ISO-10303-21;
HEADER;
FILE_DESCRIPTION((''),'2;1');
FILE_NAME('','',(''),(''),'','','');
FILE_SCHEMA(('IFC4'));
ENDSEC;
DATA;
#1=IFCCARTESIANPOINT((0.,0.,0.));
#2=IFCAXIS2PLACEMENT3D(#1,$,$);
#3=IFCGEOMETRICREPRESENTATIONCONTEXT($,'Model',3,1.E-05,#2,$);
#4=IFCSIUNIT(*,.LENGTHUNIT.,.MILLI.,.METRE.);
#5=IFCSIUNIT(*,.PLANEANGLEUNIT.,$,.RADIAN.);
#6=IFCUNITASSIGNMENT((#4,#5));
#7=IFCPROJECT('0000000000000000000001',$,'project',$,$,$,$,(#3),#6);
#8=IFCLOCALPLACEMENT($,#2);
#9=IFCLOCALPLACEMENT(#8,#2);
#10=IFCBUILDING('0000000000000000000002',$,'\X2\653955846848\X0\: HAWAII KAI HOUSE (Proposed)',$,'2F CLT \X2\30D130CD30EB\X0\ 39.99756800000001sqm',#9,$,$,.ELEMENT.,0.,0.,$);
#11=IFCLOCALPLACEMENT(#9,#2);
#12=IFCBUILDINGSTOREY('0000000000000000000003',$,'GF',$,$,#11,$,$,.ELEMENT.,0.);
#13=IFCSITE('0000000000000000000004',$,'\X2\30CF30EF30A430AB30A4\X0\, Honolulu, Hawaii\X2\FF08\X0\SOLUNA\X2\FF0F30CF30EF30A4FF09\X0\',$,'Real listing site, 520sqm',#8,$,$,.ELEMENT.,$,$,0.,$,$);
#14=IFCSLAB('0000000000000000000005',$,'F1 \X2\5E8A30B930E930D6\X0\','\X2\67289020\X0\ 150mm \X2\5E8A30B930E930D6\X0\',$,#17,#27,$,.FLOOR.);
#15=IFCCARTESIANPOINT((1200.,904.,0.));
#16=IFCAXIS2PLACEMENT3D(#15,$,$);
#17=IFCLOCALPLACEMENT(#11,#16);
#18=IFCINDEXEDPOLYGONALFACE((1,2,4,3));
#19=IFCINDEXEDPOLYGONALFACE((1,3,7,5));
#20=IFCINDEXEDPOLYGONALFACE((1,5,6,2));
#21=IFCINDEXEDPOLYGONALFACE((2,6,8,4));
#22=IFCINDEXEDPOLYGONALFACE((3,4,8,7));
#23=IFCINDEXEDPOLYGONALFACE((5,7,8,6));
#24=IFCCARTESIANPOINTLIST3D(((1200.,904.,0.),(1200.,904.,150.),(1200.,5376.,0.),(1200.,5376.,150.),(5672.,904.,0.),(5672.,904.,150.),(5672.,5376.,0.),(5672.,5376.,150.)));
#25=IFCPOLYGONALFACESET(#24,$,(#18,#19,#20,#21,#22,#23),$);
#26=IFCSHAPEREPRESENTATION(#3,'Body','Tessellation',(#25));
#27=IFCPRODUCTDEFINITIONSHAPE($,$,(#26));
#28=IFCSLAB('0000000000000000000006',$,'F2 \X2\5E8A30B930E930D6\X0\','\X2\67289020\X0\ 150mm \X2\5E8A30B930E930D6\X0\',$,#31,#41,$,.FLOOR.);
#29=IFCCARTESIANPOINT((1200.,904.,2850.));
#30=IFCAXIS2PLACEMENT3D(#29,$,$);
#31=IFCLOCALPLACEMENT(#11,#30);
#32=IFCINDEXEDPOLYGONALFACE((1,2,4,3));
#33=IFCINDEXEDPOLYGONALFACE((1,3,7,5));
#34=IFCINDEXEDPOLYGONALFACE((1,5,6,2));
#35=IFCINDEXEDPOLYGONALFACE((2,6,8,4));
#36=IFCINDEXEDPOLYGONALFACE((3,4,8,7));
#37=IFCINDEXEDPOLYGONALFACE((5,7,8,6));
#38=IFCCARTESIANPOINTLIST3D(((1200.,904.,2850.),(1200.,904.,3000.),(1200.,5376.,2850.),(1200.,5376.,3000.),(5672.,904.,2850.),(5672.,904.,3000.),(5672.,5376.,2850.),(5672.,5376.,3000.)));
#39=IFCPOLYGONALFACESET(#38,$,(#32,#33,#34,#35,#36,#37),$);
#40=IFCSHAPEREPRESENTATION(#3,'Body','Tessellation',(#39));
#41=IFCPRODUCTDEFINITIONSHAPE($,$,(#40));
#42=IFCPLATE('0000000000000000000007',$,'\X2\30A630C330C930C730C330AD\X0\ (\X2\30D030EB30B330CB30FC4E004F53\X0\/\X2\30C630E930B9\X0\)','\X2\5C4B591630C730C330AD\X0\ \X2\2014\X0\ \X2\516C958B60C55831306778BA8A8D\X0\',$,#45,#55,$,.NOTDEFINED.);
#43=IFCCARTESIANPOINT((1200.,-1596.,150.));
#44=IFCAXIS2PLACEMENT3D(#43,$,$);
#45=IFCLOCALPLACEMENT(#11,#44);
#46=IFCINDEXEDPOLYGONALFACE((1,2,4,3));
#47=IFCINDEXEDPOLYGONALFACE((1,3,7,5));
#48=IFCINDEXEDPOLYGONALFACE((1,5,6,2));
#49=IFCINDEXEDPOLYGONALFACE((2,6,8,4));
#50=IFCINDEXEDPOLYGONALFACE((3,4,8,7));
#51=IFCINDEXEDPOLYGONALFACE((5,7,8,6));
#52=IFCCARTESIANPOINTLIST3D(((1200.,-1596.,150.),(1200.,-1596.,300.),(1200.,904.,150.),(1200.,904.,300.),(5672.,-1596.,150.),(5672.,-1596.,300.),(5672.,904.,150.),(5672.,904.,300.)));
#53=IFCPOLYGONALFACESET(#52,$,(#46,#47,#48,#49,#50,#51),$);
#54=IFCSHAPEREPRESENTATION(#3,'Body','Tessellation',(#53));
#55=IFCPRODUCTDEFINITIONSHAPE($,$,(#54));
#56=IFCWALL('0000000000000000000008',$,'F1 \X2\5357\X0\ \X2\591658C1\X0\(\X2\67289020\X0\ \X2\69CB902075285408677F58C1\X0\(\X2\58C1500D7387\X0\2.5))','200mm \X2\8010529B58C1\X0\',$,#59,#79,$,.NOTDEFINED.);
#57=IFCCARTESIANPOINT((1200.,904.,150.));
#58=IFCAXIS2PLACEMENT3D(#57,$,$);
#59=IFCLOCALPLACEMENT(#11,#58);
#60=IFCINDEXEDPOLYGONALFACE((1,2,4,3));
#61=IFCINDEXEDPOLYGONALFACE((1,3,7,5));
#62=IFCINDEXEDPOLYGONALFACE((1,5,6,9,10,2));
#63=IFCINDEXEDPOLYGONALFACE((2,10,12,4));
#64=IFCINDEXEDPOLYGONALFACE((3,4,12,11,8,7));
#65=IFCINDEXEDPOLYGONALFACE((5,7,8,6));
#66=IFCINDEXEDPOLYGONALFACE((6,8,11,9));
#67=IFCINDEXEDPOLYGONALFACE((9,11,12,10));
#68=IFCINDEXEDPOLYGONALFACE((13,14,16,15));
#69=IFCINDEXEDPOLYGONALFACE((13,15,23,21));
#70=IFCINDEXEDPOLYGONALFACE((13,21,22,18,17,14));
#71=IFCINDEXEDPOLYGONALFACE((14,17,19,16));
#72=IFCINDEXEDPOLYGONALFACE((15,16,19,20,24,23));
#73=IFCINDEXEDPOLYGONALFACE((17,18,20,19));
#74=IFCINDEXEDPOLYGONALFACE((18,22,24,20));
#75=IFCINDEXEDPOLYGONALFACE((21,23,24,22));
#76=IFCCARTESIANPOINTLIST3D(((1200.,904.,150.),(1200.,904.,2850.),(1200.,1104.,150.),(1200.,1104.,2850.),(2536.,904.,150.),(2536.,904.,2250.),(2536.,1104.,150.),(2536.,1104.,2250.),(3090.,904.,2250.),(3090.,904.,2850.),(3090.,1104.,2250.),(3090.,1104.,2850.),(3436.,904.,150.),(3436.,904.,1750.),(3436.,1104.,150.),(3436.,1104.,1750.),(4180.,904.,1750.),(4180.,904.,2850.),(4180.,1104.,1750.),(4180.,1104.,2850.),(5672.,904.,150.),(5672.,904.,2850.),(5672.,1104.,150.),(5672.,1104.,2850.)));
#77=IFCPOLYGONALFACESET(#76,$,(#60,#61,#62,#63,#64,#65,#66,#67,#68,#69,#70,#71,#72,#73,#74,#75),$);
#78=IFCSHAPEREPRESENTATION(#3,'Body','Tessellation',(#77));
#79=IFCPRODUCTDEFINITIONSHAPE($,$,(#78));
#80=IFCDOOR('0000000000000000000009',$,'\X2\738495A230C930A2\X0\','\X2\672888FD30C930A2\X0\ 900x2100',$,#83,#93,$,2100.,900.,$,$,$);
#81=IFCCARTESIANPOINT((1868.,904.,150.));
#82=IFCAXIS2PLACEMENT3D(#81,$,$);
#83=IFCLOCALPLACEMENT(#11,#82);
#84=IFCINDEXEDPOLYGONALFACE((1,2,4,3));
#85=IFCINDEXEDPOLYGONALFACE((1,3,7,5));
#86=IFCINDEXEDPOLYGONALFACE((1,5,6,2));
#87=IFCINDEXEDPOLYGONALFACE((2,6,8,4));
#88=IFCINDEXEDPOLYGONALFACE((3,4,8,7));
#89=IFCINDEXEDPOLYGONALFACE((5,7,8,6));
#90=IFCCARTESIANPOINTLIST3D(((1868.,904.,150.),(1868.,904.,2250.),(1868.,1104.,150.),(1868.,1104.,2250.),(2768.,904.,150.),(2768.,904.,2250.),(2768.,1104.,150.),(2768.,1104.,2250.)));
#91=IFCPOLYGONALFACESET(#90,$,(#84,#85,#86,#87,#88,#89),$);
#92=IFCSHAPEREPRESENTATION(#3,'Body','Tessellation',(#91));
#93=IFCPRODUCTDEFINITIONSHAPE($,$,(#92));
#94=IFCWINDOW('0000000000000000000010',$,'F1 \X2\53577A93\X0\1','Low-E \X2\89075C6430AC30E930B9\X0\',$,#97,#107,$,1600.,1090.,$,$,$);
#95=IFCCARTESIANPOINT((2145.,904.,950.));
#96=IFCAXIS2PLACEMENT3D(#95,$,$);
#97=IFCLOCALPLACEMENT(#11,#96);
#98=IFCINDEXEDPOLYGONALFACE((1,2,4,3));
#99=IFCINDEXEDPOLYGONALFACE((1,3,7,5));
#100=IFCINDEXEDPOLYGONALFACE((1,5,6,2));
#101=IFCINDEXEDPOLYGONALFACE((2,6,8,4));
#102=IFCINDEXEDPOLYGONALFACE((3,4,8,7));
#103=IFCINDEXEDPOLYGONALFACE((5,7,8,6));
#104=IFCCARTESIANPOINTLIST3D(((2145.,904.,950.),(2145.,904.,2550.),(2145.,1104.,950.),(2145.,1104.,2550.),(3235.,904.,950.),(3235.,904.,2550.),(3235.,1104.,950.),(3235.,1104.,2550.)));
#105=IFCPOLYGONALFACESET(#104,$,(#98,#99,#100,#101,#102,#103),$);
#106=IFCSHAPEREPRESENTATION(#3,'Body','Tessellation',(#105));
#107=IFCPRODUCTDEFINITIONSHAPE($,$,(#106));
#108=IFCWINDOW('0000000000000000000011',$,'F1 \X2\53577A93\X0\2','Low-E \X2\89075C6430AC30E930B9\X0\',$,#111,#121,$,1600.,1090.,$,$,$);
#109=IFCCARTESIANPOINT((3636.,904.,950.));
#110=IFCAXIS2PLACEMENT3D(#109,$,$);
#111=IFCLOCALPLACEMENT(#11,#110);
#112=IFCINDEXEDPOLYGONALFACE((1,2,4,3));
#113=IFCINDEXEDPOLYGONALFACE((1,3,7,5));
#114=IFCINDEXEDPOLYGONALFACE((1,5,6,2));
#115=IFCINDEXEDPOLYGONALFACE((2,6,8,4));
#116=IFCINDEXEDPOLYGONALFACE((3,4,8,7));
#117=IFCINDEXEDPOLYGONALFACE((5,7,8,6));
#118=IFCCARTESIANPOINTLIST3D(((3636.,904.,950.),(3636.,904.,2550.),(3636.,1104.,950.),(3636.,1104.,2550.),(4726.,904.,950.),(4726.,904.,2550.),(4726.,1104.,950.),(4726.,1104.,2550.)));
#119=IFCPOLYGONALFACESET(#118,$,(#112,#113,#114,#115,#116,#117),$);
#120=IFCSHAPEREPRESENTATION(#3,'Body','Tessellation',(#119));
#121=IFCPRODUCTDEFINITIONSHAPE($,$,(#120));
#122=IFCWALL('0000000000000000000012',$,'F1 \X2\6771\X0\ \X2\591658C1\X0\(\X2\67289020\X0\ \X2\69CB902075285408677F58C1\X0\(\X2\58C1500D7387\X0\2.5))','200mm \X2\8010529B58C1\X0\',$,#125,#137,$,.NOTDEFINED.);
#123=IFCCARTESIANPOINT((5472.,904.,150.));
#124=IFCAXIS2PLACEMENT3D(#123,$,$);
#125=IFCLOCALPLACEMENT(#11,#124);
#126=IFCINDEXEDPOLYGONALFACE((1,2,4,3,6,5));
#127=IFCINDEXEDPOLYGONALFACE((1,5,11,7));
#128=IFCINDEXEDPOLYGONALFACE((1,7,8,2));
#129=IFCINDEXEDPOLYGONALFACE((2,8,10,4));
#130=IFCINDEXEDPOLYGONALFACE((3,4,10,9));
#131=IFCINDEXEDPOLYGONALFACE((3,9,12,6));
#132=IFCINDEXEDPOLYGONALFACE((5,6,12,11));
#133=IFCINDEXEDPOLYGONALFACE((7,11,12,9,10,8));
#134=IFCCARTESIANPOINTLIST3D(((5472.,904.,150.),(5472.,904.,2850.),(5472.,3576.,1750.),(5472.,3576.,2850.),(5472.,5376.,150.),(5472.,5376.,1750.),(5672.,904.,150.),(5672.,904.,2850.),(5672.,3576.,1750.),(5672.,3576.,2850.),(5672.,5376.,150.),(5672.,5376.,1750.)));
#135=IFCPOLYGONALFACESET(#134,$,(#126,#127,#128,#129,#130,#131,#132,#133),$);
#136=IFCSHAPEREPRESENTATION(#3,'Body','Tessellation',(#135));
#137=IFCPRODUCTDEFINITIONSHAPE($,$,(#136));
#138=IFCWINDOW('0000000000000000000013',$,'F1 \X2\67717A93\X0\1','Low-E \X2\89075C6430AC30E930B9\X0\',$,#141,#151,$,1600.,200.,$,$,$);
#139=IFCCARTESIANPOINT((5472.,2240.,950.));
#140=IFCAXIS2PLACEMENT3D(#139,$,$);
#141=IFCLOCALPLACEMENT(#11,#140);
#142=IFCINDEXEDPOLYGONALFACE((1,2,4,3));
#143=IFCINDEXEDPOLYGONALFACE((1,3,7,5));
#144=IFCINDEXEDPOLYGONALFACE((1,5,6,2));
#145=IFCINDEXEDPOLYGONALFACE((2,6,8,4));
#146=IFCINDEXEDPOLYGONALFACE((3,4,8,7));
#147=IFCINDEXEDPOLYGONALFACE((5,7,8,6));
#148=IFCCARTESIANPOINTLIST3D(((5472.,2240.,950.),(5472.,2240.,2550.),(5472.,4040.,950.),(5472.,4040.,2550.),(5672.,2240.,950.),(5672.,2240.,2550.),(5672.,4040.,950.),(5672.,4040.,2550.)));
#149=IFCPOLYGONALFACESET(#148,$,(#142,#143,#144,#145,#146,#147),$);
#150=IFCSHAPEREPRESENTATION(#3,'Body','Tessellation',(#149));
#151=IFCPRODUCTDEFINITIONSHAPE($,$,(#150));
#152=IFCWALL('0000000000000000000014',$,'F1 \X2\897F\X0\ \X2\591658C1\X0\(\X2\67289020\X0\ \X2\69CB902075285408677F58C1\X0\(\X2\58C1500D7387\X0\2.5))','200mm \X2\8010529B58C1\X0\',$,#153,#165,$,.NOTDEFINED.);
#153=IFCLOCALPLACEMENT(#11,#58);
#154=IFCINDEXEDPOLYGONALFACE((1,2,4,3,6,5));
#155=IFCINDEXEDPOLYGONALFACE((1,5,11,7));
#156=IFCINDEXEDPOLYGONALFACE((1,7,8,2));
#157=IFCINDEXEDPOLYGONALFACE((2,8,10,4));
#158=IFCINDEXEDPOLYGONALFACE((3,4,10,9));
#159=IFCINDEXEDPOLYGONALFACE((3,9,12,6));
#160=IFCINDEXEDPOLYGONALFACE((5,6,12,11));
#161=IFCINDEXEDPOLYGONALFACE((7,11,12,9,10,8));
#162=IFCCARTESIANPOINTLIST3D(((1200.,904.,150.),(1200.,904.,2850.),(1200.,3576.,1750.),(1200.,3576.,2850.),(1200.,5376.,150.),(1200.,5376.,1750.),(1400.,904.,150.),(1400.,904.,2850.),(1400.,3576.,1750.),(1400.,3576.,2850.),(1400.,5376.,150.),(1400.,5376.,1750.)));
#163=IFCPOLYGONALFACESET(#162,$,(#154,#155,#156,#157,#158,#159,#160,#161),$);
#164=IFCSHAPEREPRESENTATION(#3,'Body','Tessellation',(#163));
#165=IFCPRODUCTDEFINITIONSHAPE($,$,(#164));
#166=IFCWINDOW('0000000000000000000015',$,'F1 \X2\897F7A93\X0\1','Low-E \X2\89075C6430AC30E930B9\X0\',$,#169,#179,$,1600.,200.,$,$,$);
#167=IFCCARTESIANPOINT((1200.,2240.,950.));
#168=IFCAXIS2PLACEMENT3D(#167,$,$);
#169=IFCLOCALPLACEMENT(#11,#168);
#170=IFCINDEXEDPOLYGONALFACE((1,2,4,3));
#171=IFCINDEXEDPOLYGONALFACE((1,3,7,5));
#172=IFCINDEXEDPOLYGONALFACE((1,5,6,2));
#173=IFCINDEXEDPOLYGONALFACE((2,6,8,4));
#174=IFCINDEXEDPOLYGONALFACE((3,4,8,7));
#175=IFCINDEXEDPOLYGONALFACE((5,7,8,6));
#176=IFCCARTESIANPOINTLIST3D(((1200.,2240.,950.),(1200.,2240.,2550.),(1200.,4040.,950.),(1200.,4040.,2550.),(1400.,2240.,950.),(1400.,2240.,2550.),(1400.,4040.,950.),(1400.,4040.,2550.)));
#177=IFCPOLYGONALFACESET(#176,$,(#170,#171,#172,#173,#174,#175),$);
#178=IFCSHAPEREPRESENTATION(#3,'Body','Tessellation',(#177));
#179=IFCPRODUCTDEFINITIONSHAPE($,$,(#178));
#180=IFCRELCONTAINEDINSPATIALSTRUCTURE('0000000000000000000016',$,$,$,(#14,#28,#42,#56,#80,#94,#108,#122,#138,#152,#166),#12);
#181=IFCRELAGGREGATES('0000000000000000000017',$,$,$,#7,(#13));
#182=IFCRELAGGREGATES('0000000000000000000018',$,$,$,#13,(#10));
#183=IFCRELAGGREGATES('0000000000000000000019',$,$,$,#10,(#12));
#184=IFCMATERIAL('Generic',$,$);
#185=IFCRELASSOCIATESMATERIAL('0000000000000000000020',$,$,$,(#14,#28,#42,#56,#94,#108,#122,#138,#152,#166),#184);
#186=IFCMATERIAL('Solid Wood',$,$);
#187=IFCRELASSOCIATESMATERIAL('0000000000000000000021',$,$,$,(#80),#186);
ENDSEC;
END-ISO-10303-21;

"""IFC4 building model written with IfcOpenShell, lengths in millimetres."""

from ifc_helpers import new_model, si_unit, frame, frame_2d, origin, place, context, project, spatial, rectangle, extrude, material, element, fill, save


model = new_model("IFC4")

# Units and contexts
model_context = context("Model", 3, precision=1e-05, world=origin())
ifc_project = project(units=[si_unit("LENGTHUNIT", "METRE", prefix="MILLI"), si_unit("PLANEANGLEUNIT", "RADIAN")], contexts=[model_context])

# Site, building, storey
site_placement = place(None, origin())
site = spatial("IfcSite", under=ifc_project, at=site_placement, Name="ハワイカイ, Honolulu, Hawaii（SOLUNA／ハワイ）", ObjectType="Real listing site, 520sqm", CompositionType="ELEMENT", RefElevation=0.0)
building_placement = place(site_placement, origin())
building = spatial("IfcBuilding", under=site, at=building_placement, Name="改善案: HAWAII KAI HOUSE (Proposed)", ObjectType="2F CLT パネル 39.99756800000001sqm", CompositionType="ELEMENT", ElevationOfRefHeight=0.0, ElevationOfTerrain=0.0)
storey_placement = place(building_placement, origin())
storey = spatial("IfcBuildingStorey", under=building, at=storey_placement, Name="GF", CompositionType="ELEMENT", Elevation=0.0)

# Slabs
ifc_material_1 = material(Name="Generic")
slab_1_placement = place(storey_placement, frame((1200.0, 904.0, 0.0)))
element("IfcSlab", 1, at=slab_1_placement, inside=storey, material=ifc_material_1, Name="F1 床スラブ", Description="木造 150mm 床スラブ", PredefinedType="FLOOR", context=model_context, shape_type="SweptSolid", body=[
    extrude(rectangle(XDim=4472.0, YDim=4472.0, at=frame_2d((2236.0, 2236.0))), frame((1200.0, 904.0, 0.0)), (0.0, 0.0, 1.0), 150.0),
])
slab_2_placement = place(storey_placement, frame((1200.0, 904.0, 2850.0)))
element("IfcSlab", 2, at=slab_2_placement, inside=storey, material=ifc_material_1, Name="F2 床スラブ", Description="木造 150mm 床スラブ", PredefinedType="FLOOR", context=model_context, shape_type="SweptSolid", body=[
    extrude(rectangle(XDim=4472.0, YDim=4472.0, at=frame_2d((2236.0, 2236.0))), frame((1200.0, 904.0, 2850.0)), (0.0, 0.0, 1.0), 150.0),
])

# Plate
plate_placement = place(storey_placement, frame((1200.0, -1596.0, 150.0)))
element("IfcPlate", 3, at=plate_placement, inside=storey, material=ifc_material_1, Name="ウッドデッキ (バルコニー一体/テラス)", Description="屋外デッキ — 公開情報で確認", PredefinedType="NOTDEFINED", context=model_context, shape_type="SweptSolid", body=[
    extrude(rectangle(XDim=4472.0, YDim=2500.0, at=frame_2d((2236.0, 1250.0))), frame((1200.0, -1596.0, 150.0)), (0.0, 0.0, 1.0), 150.0),
])

# Wall, openings, door, windows
wall_1_placement = place(storey_placement, frame((1200.0, 904.0, 150.0)))
wall_1 = element("IfcWall", 4, at=wall_1_placement, inside=storey, material=ifc_material_1, Name="F1 南 外壁(木造 構造用合板壁(壁倍率2.5))", Description="200mm 耐力壁", PredefinedType="NOTDEFINED", context=model_context, shape_type="SweptSolid", body=[
    extrude(rectangle(XDim=4472.0, YDim=200.0, at=frame_2d((2236.0, 100.0))), frame((1200.0, 904.0, 150.0)), (0.0, 0.0, 1.0), 2700.0),
])
opening_1_placement = place(storey_placement, frame((1868.0, 904.0, 150.0)))
opening_1 = element("IfcOpeningElement", 5, at=opening_1_placement, cuts=wall_1, PredefinedType="NOTDEFINED", context=model_context, shape_type="SweptSolid", body=[
    extrude(rectangle(XDim=900.0, YDim=200.0, at=frame_2d((450.0, 100.0))), frame((1868.0, 904.0, 150.0)), (0.0, 0.0, 1.0), 2100.0),
])
opening_2_placement = place(storey_placement, frame((2145.0, 904.0, 950.0)))
opening_2 = element("IfcOpeningElement", 6, at=opening_2_placement, cuts=wall_1, PredefinedType="NOTDEFINED", context=model_context, shape_type="SweptSolid", body=[
    extrude(rectangle(XDim=1090.0, YDim=200.0, at=frame_2d((545.0, 100.0))), frame((2145.0, 904.0, 950.0)), (0.0, 0.0, 1.0), 1600.0),
])
opening_3_placement = place(storey_placement, frame((3636.0, 904.0, 950.0)))
opening_3 = element("IfcOpeningElement", 7, at=opening_3_placement, cuts=wall_1, PredefinedType="NOTDEFINED", context=model_context, shape_type="SweptSolid", body=[
    extrude(rectangle(XDim=1090.0, YDim=200.0, at=frame_2d((545.0, 100.0))), frame((3636.0, 904.0, 950.0)), (0.0, 0.0, 1.0), 1600.0),
])
ifc_material_2 = material(Name="Solid Wood")
door_placement = place(storey_placement, frame((1868.0, 904.0, 150.0)))
door = element("IfcDoor", 8, at=door_placement, inside=storey, material=ifc_material_2, Name="玄関ドア", Description="木製ドア 900x2100", OverallHeight=2100.0, OverallWidth=900.0, context=model_context, shape_type="SweptSolid", body=[
    extrude(rectangle(XDim=900.0, YDim=200.0, at=frame_2d((450.0, 100.0))), frame((1868.0, 904.0, 150.0)), (0.0, 0.0, 1.0), 2100.0),
])
fill(opening_1, door)
window_1_placement = place(storey_placement, frame((2145.0, 904.0, 950.0)))
window_1 = element("IfcWindow", 9, at=window_1_placement, inside=storey, material=ifc_material_1, Name="F1 南窓1", Description="Low-E 複層ガラス", OverallHeight=1600.0, OverallWidth=1090.0, context=model_context, shape_type="SweptSolid", body=[
    extrude(rectangle(XDim=1090.0, YDim=200.0, at=frame_2d((545.0, 100.0))), frame((2145.0, 904.0, 950.0)), (0.0, 0.0, 1.0), 1600.0),
])
fill(opening_2, window_1)
window_2_placement = place(storey_placement, frame((3636.0, 904.0, 950.0)))
window_2 = element("IfcWindow", 10, at=window_2_placement, inside=storey, material=ifc_material_1, Name="F1 南窓2", Description="Low-E 複層ガラス", OverallHeight=1600.0, OverallWidth=1090.0, context=model_context, shape_type="SweptSolid", body=[
    extrude(rectangle(XDim=1090.0, YDim=200.0, at=frame_2d((545.0, 100.0))), frame((3636.0, 904.0, 950.0)), (0.0, 0.0, 1.0), 1600.0),
])
fill(opening_3, window_2)

# Walls, openings, windows
wall_2_placement = place(storey_placement, frame((5472.0, 904.0, 150.0)))
wall_2 = element("IfcWall", 11, at=wall_2_placement, inside=storey, material=ifc_material_1, Name="F1 東 外壁(木造 構造用合板壁(壁倍率2.5))", Description="200mm 耐力壁", PredefinedType="NOTDEFINED", context=model_context, shape_type="SweptSolid", body=[
    extrude(rectangle(XDim=200.0, YDim=4472.0, at=frame_2d((100.0, 2236.0))), frame((5472.0, 904.0, 150.0)), (0.0, 0.0, 1.0), 2700.0),
])
opening_4_placement = place(storey_placement, frame((5472.0, 2240.0, 950.0)))
opening_4 = element("IfcOpeningElement", 12, at=opening_4_placement, cuts=wall_2, PredefinedType="NOTDEFINED", context=model_context, shape_type="SweptSolid", body=[
    extrude(rectangle(XDim=200.0, YDim=1800.0, at=frame_2d((100.0, 900.0))), frame((5472.0, 2240.0, 950.0)), (0.0, 0.0, 1.0), 1600.0),
])
window_3_placement = place(storey_placement, frame((5472.0, 2240.0, 950.0)))
window_3 = element("IfcWindow", 13, at=window_3_placement, inside=storey, material=ifc_material_1, Name="F1 東窓1", Description="Low-E 複層ガラス", OverallHeight=1600.0, OverallWidth=200.0, context=model_context, shape_type="SweptSolid", body=[
    extrude(rectangle(XDim=200.0, YDim=1800.0, at=frame_2d((100.0, 900.0))), frame((5472.0, 2240.0, 950.0)), (0.0, 0.0, 1.0), 1600.0),
])
fill(opening_4, window_3)
wall_3_placement = place(storey_placement, frame((1200.0, 904.0, 150.0)))
wall_3 = element("IfcWall", 14, at=wall_3_placement, inside=storey, material=ifc_material_1, Name="F1 西 外壁(木造 構造用合板壁(壁倍率2.5))", Description="200mm 耐力壁", PredefinedType="NOTDEFINED", context=model_context, shape_type="SweptSolid", body=[
    extrude(rectangle(XDim=200.0, YDim=4472.0, at=frame_2d((100.0, 2236.0))), frame((1200.0, 904.0, 150.0)), (0.0, 0.0, 1.0), 2700.0),
])
opening_5_placement = place(storey_placement, frame((1200.0, 2240.0, 950.0)))
opening_5 = element("IfcOpeningElement", 15, at=opening_5_placement, cuts=wall_3, PredefinedType="NOTDEFINED", context=model_context, shape_type="SweptSolid", body=[
    extrude(rectangle(XDim=200.0, YDim=1800.0, at=frame_2d((100.0, 900.0))), frame((1200.0, 2240.0, 950.0)), (0.0, 0.0, 1.0), 1600.0),
])
window_4_placement = place(storey_placement, frame((1200.0, 2240.0, 950.0)))
window_4 = element("IfcWindow", 16, at=window_4_placement, inside=storey, material=ifc_material_1, Name="F1 西窓1", Description="Low-E 複層ガラス", OverallHeight=1600.0, OverallWidth=200.0, context=model_context, shape_type="SweptSolid", body=[
    extrude(rectangle(XDim=200.0, YDim=1800.0, at=frame_2d((100.0, 900.0))), frame((1200.0, 2240.0, 950.0)), (0.0, 0.0, 1.0), 1600.0),
])
fill(opening_5, window_4)

save(model, "model.ifc")
